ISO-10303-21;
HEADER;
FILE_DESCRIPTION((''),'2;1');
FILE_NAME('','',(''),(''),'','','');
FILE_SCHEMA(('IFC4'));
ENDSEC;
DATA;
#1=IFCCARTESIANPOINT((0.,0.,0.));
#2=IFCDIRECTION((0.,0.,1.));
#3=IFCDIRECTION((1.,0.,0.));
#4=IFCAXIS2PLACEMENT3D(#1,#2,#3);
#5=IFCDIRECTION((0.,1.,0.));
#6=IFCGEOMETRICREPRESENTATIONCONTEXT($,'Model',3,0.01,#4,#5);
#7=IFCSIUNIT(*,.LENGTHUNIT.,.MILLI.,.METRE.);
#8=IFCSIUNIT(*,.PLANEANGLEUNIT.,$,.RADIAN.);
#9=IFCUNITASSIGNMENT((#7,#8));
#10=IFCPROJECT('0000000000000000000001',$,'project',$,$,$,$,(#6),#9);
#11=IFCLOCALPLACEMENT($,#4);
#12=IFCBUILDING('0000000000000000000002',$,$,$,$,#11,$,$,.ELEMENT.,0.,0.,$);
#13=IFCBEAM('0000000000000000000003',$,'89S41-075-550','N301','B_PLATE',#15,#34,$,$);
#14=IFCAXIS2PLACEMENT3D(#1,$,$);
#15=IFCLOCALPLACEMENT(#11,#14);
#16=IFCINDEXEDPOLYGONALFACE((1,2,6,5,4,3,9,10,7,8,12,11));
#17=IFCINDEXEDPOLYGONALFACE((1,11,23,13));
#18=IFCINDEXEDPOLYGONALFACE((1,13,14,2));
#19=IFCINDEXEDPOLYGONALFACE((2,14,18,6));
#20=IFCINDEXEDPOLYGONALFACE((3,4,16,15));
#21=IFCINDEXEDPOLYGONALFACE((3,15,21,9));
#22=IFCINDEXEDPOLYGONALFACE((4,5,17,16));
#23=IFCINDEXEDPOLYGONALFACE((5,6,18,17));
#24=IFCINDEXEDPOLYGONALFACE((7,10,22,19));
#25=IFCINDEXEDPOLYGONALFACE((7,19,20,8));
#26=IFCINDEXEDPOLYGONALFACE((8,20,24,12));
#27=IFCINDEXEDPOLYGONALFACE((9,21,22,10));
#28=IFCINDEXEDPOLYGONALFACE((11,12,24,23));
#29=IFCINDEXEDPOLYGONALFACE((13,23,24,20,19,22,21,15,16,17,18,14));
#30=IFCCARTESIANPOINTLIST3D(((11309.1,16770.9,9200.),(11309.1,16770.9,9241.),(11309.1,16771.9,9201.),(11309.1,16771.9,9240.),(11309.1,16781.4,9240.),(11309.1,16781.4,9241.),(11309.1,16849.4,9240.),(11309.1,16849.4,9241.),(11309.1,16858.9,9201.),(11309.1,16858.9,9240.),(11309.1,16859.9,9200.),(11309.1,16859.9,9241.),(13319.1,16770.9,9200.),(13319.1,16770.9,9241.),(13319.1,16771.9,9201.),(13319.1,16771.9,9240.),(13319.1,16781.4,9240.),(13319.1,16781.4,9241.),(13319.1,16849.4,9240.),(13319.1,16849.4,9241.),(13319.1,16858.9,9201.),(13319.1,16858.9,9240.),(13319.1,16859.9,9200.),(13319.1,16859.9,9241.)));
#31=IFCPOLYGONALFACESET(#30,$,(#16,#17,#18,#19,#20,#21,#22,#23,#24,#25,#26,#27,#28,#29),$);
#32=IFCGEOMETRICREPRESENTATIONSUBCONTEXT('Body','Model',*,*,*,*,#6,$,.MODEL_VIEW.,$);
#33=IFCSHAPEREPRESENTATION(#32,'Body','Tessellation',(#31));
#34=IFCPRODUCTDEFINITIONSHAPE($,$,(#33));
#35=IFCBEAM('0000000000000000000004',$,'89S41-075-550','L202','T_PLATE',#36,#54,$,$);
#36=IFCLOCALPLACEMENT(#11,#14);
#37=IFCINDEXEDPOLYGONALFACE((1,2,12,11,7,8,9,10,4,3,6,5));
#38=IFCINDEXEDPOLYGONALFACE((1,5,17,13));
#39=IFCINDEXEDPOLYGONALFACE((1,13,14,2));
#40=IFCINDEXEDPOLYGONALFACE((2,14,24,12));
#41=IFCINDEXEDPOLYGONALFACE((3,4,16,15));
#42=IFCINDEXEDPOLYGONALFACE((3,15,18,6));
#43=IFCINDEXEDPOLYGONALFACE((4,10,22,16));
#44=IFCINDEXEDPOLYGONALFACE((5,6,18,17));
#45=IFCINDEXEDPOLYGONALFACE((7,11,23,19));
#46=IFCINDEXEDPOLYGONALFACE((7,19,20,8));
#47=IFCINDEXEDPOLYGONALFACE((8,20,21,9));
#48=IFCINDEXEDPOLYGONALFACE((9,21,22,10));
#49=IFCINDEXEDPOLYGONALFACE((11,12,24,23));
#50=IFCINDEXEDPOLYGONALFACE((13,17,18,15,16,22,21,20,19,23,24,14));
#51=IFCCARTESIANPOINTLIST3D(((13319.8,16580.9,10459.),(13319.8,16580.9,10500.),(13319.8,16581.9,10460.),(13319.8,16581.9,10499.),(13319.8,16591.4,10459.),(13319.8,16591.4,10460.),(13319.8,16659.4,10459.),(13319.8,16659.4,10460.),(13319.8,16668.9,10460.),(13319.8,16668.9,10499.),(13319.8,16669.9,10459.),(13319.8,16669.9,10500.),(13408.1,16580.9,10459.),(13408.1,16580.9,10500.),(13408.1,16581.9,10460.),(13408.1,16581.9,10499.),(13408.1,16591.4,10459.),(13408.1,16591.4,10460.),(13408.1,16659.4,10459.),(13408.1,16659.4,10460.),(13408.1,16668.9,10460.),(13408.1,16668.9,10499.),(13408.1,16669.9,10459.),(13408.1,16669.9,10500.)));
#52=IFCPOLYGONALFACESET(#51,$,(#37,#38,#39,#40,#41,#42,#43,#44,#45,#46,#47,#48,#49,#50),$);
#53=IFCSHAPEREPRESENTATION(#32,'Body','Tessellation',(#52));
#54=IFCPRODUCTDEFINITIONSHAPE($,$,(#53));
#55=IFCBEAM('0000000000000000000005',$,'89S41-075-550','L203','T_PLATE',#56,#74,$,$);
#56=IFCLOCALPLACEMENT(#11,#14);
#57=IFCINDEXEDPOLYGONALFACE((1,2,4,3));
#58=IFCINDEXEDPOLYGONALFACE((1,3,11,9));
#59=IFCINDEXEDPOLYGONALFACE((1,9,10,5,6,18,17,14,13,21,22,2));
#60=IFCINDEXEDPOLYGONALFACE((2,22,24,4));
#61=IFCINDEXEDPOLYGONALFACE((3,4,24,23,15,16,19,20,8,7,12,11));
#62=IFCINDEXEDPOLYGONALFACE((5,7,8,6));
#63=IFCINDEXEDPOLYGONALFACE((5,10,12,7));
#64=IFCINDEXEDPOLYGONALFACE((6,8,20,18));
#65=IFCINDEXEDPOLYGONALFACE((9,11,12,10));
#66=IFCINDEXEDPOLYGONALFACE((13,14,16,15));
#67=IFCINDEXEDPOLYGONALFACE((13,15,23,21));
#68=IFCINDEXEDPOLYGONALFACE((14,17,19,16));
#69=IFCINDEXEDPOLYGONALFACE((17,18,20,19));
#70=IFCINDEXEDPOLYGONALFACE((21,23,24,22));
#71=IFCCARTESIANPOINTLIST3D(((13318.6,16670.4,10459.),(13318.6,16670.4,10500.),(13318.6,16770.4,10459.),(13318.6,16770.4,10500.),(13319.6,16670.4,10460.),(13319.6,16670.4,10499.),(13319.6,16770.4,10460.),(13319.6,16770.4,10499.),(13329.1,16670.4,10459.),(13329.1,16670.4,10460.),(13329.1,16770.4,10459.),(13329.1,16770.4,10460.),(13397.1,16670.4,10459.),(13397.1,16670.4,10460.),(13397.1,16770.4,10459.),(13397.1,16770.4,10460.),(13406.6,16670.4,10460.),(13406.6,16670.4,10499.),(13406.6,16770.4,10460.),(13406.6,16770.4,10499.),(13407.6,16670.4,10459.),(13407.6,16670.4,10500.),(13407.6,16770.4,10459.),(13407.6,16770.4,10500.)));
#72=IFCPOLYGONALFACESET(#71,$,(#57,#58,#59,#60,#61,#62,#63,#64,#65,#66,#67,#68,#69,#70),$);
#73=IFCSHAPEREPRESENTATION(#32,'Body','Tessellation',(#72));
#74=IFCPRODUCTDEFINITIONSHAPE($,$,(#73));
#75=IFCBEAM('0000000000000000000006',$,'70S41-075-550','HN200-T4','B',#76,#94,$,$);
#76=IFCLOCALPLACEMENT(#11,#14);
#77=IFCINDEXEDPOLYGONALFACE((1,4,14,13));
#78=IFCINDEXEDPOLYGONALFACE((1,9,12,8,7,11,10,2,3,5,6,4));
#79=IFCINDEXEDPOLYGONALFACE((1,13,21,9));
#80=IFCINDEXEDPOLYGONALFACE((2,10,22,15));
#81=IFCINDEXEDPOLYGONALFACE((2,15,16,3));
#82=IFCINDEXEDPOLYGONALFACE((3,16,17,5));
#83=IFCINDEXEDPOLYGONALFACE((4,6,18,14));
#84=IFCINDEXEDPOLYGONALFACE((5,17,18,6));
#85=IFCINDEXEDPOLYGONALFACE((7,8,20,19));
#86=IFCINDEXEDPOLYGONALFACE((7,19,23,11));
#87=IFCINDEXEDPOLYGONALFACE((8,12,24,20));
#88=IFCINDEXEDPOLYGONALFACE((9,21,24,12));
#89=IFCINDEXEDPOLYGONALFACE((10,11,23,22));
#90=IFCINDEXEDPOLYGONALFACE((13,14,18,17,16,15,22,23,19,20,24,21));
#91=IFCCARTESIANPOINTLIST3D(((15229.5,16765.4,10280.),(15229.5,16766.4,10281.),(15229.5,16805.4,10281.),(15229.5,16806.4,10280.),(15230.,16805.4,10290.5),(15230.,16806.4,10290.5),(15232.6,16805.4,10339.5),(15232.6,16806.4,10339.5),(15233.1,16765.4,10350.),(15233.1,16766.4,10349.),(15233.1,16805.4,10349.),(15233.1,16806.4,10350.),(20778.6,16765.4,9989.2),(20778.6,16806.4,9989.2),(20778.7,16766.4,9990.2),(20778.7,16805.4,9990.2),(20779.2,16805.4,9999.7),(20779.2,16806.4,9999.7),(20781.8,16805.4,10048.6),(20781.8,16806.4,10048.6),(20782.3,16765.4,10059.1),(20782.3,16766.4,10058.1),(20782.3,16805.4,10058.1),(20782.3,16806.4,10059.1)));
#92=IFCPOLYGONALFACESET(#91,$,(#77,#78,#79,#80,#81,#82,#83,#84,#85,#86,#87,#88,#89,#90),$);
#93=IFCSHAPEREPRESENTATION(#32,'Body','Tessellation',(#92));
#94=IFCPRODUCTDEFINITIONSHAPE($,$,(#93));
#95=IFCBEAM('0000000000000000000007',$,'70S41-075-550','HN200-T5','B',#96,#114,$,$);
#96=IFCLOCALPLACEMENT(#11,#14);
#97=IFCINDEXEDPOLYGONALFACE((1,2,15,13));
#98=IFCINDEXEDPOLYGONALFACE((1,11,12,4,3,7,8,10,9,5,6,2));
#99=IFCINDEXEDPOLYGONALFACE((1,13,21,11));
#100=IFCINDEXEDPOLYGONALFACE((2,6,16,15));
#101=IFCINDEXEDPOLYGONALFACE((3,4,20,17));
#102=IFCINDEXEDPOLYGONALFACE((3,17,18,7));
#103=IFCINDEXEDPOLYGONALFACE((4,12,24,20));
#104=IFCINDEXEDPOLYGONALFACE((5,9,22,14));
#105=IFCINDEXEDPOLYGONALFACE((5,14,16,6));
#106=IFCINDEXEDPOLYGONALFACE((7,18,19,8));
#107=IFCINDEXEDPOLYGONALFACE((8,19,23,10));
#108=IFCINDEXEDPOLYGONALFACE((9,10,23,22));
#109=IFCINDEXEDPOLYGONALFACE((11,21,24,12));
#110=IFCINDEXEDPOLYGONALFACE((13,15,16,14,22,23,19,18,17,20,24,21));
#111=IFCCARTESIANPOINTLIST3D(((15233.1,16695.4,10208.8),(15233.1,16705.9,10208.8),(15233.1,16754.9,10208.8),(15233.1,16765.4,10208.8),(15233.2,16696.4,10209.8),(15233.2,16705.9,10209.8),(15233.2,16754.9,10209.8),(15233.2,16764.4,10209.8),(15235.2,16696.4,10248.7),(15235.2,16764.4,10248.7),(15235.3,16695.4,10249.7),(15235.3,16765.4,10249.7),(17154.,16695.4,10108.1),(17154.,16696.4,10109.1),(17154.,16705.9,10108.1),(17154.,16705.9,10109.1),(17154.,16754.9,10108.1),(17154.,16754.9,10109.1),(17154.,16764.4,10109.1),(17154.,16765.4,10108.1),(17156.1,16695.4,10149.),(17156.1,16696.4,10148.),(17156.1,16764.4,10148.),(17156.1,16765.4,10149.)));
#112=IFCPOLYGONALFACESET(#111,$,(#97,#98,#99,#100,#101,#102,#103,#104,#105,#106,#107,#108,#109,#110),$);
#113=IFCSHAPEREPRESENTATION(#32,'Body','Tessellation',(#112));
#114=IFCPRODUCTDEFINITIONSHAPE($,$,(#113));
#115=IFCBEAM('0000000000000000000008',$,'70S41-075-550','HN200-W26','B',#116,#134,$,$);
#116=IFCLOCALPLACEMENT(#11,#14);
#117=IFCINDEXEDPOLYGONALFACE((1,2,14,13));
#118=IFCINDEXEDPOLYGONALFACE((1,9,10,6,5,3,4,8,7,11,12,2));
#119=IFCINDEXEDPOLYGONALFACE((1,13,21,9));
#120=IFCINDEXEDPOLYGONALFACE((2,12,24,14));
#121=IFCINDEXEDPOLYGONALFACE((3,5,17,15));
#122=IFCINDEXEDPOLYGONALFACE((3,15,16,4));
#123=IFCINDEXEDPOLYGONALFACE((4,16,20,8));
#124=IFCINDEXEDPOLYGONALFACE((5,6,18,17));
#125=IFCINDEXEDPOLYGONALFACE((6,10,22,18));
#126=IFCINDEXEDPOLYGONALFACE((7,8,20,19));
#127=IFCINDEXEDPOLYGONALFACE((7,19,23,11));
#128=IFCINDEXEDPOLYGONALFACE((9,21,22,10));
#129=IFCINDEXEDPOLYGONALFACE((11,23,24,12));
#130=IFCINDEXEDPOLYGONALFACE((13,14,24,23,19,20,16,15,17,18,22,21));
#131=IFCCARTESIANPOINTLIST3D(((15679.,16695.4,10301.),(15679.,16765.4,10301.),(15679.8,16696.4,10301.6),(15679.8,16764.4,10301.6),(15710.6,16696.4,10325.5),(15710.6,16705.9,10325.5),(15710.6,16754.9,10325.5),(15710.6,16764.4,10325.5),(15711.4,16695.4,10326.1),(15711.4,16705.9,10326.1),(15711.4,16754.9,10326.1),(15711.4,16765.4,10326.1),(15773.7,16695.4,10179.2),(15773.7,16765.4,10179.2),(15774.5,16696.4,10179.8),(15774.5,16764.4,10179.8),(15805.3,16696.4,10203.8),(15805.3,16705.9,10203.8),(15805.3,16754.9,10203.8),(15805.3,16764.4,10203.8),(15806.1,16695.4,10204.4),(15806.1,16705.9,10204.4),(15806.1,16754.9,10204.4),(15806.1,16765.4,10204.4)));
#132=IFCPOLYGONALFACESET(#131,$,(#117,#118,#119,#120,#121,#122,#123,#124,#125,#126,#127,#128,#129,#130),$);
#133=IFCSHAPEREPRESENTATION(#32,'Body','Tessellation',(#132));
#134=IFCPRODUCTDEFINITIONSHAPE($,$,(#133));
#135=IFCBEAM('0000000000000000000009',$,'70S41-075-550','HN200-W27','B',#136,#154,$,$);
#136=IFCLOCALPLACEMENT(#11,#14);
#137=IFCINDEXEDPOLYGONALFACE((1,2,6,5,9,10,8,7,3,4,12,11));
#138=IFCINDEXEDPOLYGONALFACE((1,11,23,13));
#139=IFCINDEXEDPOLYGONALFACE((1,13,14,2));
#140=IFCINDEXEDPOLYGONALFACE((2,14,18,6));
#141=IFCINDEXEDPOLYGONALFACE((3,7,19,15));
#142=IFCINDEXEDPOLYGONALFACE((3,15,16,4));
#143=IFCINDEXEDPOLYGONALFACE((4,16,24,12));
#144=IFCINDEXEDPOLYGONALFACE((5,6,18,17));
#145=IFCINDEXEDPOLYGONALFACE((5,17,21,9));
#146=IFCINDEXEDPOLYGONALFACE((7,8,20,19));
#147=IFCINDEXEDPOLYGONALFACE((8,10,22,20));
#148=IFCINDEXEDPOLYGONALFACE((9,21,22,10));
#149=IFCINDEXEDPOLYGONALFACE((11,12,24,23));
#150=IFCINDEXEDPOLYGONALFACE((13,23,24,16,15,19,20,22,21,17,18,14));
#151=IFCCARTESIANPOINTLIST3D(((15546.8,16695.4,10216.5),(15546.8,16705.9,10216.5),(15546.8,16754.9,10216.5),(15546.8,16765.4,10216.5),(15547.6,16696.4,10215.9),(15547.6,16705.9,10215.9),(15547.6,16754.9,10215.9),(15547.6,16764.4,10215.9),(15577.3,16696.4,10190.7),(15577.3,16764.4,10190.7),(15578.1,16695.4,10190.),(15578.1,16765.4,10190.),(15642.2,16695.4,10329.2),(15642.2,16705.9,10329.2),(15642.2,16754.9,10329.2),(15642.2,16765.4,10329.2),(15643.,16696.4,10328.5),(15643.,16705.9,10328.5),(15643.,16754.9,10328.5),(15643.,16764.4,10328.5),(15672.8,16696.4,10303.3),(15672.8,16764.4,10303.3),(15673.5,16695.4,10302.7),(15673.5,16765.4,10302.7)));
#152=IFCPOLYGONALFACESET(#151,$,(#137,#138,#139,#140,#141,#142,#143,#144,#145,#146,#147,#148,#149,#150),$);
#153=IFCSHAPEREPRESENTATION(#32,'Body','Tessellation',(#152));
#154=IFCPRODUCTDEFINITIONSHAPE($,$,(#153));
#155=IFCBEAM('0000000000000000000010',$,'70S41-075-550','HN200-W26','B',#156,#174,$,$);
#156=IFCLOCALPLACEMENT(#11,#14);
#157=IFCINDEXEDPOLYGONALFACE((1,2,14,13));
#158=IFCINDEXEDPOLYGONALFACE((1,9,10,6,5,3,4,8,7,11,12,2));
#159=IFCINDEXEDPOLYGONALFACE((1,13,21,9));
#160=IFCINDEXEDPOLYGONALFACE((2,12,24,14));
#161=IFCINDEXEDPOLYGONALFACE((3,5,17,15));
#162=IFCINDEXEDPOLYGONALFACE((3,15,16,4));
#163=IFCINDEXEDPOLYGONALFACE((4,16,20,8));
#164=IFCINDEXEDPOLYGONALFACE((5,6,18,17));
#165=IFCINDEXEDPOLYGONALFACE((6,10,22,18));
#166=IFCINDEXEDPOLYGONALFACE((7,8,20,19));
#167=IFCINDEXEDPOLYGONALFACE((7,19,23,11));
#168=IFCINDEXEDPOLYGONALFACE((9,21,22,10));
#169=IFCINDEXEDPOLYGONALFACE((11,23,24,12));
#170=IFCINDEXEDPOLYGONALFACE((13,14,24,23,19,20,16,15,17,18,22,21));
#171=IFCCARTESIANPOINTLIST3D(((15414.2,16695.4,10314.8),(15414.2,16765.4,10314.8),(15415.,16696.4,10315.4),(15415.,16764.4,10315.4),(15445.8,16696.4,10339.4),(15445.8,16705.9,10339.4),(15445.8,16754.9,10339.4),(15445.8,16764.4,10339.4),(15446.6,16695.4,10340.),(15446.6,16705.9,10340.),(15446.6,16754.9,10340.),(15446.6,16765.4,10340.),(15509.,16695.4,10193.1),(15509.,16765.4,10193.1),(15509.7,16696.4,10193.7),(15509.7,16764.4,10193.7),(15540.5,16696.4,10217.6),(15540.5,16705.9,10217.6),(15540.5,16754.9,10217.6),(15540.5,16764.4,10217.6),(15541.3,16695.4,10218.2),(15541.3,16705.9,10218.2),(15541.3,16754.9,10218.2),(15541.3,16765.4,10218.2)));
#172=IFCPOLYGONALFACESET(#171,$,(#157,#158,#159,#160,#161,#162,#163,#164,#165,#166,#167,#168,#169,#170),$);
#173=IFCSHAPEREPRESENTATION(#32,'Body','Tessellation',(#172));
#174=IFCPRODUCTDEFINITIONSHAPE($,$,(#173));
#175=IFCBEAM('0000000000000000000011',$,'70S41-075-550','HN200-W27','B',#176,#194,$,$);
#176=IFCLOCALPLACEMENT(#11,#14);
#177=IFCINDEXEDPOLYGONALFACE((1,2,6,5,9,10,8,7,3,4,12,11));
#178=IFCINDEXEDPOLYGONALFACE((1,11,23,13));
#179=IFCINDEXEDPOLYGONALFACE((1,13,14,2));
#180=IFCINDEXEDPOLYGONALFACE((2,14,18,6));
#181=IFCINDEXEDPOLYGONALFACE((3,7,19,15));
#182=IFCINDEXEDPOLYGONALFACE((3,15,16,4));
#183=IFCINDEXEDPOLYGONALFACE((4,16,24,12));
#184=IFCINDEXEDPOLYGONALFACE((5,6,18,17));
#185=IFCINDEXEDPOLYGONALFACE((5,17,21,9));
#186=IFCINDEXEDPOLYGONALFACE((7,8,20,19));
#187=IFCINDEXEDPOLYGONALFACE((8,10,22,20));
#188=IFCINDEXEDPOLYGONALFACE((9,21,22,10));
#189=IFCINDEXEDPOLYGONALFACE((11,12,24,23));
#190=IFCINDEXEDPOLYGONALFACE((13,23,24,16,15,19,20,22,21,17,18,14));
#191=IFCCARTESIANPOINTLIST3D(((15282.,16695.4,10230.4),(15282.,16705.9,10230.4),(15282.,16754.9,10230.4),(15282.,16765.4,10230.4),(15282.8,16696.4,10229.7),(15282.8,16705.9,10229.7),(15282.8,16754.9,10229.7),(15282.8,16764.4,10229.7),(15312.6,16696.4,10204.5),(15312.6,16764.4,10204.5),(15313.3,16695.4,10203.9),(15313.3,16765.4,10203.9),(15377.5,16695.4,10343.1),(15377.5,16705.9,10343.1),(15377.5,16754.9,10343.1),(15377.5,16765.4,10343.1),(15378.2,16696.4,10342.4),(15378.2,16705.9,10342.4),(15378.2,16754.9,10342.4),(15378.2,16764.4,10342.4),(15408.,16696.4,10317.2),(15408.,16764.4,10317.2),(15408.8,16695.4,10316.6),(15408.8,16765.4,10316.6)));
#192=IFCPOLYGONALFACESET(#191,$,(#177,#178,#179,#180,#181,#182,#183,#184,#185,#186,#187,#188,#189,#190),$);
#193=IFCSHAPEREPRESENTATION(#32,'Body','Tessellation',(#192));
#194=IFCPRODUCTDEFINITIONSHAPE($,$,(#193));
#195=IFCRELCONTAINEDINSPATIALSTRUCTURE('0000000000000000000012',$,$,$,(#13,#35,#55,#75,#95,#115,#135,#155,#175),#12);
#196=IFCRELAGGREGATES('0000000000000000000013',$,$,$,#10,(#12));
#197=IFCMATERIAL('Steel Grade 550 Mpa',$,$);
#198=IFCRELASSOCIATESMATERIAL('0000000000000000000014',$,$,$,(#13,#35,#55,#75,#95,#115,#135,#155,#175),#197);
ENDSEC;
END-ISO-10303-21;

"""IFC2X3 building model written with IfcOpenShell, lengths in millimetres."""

from ifc_helpers import new_model, si_unit, direction, frame, origin, origin_with_axes, origin_2d_with_axis, place, context, subcontext, project, spatial, c_section, extrude, source, transform, mapped, material, element, save


model = new_model("IFC2X3")

# Units and contexts
model_context = context("Model", 3, precision=0.01, world=origin_with_axes(), true_north=direction((0.0, 1.0, 0.0)))
body_context = subcontext(model_context, "Body", "Model", "MODEL_VIEW")
ifc_project = project(units=[si_unit("LENGTHUNIT", "METRE", prefix="MILLI"), si_unit("PLANEANGLEUNIT", "RADIAN")], contexts=[model_context])

# Building
building_placement = place(None, origin_with_axes())
building = spatial("IfcBuilding", under=ifc_project, at=building_placement, CompositionType="ELEMENT", ElevationOfRefHeight=0.0, ElevationOfTerrain=0.0)

# Shared definitions
ifc_material = material(Name="Steel Grade 550 Mpa")

# Beams
shared_shape_1 = source(origin(), body_context, "Body", "SweptSolid", [
    extrude(c_section(Depth=89.0, Width=41.0, WallThickness=1.0, Girth=10.5, at=origin_2d_with_axis()), origin_with_axes(), (0.0, 0.0, 1.0), 2010.0),
])
beam_1_placement = place(None, frame((13319.1, 16815.4, 9220.5), z_axis=(-1.0, 0.0, 0.0), x_axis=(0.0, 0.0, 1.0)))
element("IfcBeam", 1, at=beam_1_placement, inside=building, material=ifc_material, Name="89S41-075-550", Description="N301", ObjectType="B_PLATE", context=body_context, shape_type="MappedRepresentation", body=[
    mapped(shared_shape_1, transform((0.0, 0.0, 0.0), scale=1.0)),
])
shared_shape_2 = source(origin(), body_context, "Body", "SweptSolid", [
    extrude(c_section(Depth=89.0, Width=41.0, WallThickness=1.0, Girth=10.5, at=origin_2d_with_axis()), origin_with_axes(), (0.0, 0.0, 1.0), 88.3),
])
beam_2_placement = place(None, frame((13319.8, 16625.4, 10479.5), z_axis=(1.0, 0.0, 0.0), x_axis=(0.0, 0.0, -1.0)))
element("IfcBeam", 2, at=beam_2_placement, inside=building, material=ifc_material, Name="89S41-075-550", Description="L202", ObjectType="T_PLATE", context=body_context, shape_type="MappedRepresentation", body=[
    mapped(shared_shape_2, transform((0.0, 0.0, 0.0), scale=1.0)),
])
shared_shape_3 = source(origin(), body_context, "Body", "SweptSolid", [
    extrude(c_section(Depth=89.0, Width=41.0, WallThickness=1.0, Girth=10.5, at=origin_2d_with_axis()), origin_with_axes(), (0.0, 0.0, 1.0), 100.0),
])
beam_3_placement = place(None, frame((13363.1, 16670.4, 10479.5), z_axis=(0.0, 1.0, 0.0), x_axis=(0.0, 0.0, -1.0)))
element("IfcBeam", 3, at=beam_3_placement, inside=building, material=ifc_material, Name="89S41-075-550", Description="L203", ObjectType="T_PLATE", context=body_context, shape_type="MappedRepresentation", body=[
    mapped(shared_shape_3, transform((0.0, 0.0, 0.0), scale=1.0)),
])
shared_shape_4 = source(origin(), body_context, "Body", "SweptSolid", [
    extrude(c_section(Depth=70.0, Width=41.0, WallThickness=1.0, Girth=10.5, at=origin_2d_with_axis()), origin_with_axes(), (0.0, 0.0, 1.0), 5556.8),
])
beam_4_placement = place(None, frame((15231.3, 16785.9, 10315.0), z_axis=(0.99863, 0.0, -0.052336), x_axis=(0.0, 1.0, 0.0)))
element("IfcBeam", 4, at=beam_4_placement, inside=building, material=ifc_material, Name="70S41-075-550", Description="HN200-T4", ObjectType="B", context=body_context, shape_type="MappedRepresentation", body=[
    mapped(shared_shape_4, transform((0.0, 0.0, 0.0), scale=1.0)),
])
shared_shape_5 = source(origin(), body_context, "Body", "SweptSolid", [
    extrude(c_section(Depth=70.0, Width=41.0, WallThickness=1.0, Girth=10.5, at=origin_2d_with_axis()), origin_with_axes(), (0.0, 0.0, 1.0), 1923.5),
])
beam_5_placement = place(None, frame((15234.2, 16730.4, 10229.2), z_axis=(0.99863, 0.0, -0.052336), x_axis=(-0.052336, 0.0, -0.99863)))
element("IfcBeam", 5, at=beam_5_placement, inside=building, material=ifc_material, Name="70S41-075-550", Description="HN200-T5", ObjectType="B", context=body_context, shape_type="MappedRepresentation", body=[
    mapped(shared_shape_5, transform((0.0, 0.0, 0.0), scale=1.0)),
])
shared_shape_6 = source(origin(), body_context, "Body", "SweptSolid", [
    extrude(c_section(Depth=70.0, Width=41.0, WallThickness=1.0, Girth=10.5, at=origin_2d_with_axis()), origin_with_axes(), (0.0, 0.0, 1.0), 154.3),
])
beam_6_placement = place(None, frame((15789.9, 16730.4, 10191.8), z_axis=(-0.613981, 0.0, 0.789321), x_axis=(0.789321, 0.0, 0.613981)))
element("IfcBeam", 6, at=beam_6_placement, inside=building, material=ifc_material, Name="70S41-075-550", Description="HN200-W26", ObjectType="B", context=body_context, shape_type="MappedRepresentation", body=[
    mapped(shared_shape_6, transform((0.0, 0.0, 0.0), scale=1.0)),
])
shared_shape_7 = source(origin(), body_context, "Body", "SweptSolid", [
    extrude(c_section(Depth=70.0, Width=41.0, WallThickness=1.0, Girth=10.5, at=origin_2d_with_axis()), origin_with_axes(), (0.0, 0.0, 1.0), 147.6),
])
beam_7_placement = place(None, frame((15657.9, 16730.4, 10315.9), z_axis=(-0.646275, 0.0, -0.763105), x_axis=(-0.763105, 0.0, 0.646275)))
element("IfcBeam", 7, at=beam_7_placement, inside=building, material=ifc_material, Name="70S41-075-550", Description="HN200-W27", ObjectType="B", context=body_context, shape_type="MappedRepresentation", body=[
    mapped(shared_shape_7, transform((0.0, 0.0, 0.0), scale=1.0)),
])
shared_shape_8 = source(origin(), body_context, "Body", "SweptSolid", [
    extrude(c_section(Depth=70.0, Width=41.0, WallThickness=1.0, Girth=10.5, at=origin_2d_with_axis()), origin_with_axes(), (0.0, 0.0, 1.0), 154.3),
])
beam_8_placement = place(None, frame((15525.1, 16730.4, 10205.7), z_axis=(-0.613981, 0.0, 0.789321), x_axis=(0.789321, 0.0, 0.613981)))
element("IfcBeam", 8, at=beam_8_placement, inside=building, material=ifc_material, Name="70S41-075-550", Description="HN200-W26", ObjectType="B", context=body_context, shape_type="MappedRepresentation", body=[
    mapped(shared_shape_8, transform((0.0, 0.0, 0.0), scale=1.0)),
])
shared_shape_9 = source(origin(), body_context, "Body", "SweptSolid", [
    extrude(c_section(Depth=70.0, Width=41.0, WallThickness=1.0, Girth=10.5, at=origin_2d_with_axis()), origin_with_axes(), (0.0, 0.0, 1.0), 147.6),
])
beam_9_placement = place(None, frame((15393.1, 16730.4, 10329.8), z_axis=(-0.646275, 0.0, -0.763105), x_axis=(-0.763105, 0.0, 0.646275)))
element("IfcBeam", 9, at=beam_9_placement, inside=building, material=ifc_material, Name="70S41-075-550", Description="HN200-W27", ObjectType="B", context=body_context, shape_type="MappedRepresentation", body=[
    mapped(shared_shape_9, transform((0.0, 0.0, 0.0), scale=1.0)),
])

save(model, "model.ifc")
